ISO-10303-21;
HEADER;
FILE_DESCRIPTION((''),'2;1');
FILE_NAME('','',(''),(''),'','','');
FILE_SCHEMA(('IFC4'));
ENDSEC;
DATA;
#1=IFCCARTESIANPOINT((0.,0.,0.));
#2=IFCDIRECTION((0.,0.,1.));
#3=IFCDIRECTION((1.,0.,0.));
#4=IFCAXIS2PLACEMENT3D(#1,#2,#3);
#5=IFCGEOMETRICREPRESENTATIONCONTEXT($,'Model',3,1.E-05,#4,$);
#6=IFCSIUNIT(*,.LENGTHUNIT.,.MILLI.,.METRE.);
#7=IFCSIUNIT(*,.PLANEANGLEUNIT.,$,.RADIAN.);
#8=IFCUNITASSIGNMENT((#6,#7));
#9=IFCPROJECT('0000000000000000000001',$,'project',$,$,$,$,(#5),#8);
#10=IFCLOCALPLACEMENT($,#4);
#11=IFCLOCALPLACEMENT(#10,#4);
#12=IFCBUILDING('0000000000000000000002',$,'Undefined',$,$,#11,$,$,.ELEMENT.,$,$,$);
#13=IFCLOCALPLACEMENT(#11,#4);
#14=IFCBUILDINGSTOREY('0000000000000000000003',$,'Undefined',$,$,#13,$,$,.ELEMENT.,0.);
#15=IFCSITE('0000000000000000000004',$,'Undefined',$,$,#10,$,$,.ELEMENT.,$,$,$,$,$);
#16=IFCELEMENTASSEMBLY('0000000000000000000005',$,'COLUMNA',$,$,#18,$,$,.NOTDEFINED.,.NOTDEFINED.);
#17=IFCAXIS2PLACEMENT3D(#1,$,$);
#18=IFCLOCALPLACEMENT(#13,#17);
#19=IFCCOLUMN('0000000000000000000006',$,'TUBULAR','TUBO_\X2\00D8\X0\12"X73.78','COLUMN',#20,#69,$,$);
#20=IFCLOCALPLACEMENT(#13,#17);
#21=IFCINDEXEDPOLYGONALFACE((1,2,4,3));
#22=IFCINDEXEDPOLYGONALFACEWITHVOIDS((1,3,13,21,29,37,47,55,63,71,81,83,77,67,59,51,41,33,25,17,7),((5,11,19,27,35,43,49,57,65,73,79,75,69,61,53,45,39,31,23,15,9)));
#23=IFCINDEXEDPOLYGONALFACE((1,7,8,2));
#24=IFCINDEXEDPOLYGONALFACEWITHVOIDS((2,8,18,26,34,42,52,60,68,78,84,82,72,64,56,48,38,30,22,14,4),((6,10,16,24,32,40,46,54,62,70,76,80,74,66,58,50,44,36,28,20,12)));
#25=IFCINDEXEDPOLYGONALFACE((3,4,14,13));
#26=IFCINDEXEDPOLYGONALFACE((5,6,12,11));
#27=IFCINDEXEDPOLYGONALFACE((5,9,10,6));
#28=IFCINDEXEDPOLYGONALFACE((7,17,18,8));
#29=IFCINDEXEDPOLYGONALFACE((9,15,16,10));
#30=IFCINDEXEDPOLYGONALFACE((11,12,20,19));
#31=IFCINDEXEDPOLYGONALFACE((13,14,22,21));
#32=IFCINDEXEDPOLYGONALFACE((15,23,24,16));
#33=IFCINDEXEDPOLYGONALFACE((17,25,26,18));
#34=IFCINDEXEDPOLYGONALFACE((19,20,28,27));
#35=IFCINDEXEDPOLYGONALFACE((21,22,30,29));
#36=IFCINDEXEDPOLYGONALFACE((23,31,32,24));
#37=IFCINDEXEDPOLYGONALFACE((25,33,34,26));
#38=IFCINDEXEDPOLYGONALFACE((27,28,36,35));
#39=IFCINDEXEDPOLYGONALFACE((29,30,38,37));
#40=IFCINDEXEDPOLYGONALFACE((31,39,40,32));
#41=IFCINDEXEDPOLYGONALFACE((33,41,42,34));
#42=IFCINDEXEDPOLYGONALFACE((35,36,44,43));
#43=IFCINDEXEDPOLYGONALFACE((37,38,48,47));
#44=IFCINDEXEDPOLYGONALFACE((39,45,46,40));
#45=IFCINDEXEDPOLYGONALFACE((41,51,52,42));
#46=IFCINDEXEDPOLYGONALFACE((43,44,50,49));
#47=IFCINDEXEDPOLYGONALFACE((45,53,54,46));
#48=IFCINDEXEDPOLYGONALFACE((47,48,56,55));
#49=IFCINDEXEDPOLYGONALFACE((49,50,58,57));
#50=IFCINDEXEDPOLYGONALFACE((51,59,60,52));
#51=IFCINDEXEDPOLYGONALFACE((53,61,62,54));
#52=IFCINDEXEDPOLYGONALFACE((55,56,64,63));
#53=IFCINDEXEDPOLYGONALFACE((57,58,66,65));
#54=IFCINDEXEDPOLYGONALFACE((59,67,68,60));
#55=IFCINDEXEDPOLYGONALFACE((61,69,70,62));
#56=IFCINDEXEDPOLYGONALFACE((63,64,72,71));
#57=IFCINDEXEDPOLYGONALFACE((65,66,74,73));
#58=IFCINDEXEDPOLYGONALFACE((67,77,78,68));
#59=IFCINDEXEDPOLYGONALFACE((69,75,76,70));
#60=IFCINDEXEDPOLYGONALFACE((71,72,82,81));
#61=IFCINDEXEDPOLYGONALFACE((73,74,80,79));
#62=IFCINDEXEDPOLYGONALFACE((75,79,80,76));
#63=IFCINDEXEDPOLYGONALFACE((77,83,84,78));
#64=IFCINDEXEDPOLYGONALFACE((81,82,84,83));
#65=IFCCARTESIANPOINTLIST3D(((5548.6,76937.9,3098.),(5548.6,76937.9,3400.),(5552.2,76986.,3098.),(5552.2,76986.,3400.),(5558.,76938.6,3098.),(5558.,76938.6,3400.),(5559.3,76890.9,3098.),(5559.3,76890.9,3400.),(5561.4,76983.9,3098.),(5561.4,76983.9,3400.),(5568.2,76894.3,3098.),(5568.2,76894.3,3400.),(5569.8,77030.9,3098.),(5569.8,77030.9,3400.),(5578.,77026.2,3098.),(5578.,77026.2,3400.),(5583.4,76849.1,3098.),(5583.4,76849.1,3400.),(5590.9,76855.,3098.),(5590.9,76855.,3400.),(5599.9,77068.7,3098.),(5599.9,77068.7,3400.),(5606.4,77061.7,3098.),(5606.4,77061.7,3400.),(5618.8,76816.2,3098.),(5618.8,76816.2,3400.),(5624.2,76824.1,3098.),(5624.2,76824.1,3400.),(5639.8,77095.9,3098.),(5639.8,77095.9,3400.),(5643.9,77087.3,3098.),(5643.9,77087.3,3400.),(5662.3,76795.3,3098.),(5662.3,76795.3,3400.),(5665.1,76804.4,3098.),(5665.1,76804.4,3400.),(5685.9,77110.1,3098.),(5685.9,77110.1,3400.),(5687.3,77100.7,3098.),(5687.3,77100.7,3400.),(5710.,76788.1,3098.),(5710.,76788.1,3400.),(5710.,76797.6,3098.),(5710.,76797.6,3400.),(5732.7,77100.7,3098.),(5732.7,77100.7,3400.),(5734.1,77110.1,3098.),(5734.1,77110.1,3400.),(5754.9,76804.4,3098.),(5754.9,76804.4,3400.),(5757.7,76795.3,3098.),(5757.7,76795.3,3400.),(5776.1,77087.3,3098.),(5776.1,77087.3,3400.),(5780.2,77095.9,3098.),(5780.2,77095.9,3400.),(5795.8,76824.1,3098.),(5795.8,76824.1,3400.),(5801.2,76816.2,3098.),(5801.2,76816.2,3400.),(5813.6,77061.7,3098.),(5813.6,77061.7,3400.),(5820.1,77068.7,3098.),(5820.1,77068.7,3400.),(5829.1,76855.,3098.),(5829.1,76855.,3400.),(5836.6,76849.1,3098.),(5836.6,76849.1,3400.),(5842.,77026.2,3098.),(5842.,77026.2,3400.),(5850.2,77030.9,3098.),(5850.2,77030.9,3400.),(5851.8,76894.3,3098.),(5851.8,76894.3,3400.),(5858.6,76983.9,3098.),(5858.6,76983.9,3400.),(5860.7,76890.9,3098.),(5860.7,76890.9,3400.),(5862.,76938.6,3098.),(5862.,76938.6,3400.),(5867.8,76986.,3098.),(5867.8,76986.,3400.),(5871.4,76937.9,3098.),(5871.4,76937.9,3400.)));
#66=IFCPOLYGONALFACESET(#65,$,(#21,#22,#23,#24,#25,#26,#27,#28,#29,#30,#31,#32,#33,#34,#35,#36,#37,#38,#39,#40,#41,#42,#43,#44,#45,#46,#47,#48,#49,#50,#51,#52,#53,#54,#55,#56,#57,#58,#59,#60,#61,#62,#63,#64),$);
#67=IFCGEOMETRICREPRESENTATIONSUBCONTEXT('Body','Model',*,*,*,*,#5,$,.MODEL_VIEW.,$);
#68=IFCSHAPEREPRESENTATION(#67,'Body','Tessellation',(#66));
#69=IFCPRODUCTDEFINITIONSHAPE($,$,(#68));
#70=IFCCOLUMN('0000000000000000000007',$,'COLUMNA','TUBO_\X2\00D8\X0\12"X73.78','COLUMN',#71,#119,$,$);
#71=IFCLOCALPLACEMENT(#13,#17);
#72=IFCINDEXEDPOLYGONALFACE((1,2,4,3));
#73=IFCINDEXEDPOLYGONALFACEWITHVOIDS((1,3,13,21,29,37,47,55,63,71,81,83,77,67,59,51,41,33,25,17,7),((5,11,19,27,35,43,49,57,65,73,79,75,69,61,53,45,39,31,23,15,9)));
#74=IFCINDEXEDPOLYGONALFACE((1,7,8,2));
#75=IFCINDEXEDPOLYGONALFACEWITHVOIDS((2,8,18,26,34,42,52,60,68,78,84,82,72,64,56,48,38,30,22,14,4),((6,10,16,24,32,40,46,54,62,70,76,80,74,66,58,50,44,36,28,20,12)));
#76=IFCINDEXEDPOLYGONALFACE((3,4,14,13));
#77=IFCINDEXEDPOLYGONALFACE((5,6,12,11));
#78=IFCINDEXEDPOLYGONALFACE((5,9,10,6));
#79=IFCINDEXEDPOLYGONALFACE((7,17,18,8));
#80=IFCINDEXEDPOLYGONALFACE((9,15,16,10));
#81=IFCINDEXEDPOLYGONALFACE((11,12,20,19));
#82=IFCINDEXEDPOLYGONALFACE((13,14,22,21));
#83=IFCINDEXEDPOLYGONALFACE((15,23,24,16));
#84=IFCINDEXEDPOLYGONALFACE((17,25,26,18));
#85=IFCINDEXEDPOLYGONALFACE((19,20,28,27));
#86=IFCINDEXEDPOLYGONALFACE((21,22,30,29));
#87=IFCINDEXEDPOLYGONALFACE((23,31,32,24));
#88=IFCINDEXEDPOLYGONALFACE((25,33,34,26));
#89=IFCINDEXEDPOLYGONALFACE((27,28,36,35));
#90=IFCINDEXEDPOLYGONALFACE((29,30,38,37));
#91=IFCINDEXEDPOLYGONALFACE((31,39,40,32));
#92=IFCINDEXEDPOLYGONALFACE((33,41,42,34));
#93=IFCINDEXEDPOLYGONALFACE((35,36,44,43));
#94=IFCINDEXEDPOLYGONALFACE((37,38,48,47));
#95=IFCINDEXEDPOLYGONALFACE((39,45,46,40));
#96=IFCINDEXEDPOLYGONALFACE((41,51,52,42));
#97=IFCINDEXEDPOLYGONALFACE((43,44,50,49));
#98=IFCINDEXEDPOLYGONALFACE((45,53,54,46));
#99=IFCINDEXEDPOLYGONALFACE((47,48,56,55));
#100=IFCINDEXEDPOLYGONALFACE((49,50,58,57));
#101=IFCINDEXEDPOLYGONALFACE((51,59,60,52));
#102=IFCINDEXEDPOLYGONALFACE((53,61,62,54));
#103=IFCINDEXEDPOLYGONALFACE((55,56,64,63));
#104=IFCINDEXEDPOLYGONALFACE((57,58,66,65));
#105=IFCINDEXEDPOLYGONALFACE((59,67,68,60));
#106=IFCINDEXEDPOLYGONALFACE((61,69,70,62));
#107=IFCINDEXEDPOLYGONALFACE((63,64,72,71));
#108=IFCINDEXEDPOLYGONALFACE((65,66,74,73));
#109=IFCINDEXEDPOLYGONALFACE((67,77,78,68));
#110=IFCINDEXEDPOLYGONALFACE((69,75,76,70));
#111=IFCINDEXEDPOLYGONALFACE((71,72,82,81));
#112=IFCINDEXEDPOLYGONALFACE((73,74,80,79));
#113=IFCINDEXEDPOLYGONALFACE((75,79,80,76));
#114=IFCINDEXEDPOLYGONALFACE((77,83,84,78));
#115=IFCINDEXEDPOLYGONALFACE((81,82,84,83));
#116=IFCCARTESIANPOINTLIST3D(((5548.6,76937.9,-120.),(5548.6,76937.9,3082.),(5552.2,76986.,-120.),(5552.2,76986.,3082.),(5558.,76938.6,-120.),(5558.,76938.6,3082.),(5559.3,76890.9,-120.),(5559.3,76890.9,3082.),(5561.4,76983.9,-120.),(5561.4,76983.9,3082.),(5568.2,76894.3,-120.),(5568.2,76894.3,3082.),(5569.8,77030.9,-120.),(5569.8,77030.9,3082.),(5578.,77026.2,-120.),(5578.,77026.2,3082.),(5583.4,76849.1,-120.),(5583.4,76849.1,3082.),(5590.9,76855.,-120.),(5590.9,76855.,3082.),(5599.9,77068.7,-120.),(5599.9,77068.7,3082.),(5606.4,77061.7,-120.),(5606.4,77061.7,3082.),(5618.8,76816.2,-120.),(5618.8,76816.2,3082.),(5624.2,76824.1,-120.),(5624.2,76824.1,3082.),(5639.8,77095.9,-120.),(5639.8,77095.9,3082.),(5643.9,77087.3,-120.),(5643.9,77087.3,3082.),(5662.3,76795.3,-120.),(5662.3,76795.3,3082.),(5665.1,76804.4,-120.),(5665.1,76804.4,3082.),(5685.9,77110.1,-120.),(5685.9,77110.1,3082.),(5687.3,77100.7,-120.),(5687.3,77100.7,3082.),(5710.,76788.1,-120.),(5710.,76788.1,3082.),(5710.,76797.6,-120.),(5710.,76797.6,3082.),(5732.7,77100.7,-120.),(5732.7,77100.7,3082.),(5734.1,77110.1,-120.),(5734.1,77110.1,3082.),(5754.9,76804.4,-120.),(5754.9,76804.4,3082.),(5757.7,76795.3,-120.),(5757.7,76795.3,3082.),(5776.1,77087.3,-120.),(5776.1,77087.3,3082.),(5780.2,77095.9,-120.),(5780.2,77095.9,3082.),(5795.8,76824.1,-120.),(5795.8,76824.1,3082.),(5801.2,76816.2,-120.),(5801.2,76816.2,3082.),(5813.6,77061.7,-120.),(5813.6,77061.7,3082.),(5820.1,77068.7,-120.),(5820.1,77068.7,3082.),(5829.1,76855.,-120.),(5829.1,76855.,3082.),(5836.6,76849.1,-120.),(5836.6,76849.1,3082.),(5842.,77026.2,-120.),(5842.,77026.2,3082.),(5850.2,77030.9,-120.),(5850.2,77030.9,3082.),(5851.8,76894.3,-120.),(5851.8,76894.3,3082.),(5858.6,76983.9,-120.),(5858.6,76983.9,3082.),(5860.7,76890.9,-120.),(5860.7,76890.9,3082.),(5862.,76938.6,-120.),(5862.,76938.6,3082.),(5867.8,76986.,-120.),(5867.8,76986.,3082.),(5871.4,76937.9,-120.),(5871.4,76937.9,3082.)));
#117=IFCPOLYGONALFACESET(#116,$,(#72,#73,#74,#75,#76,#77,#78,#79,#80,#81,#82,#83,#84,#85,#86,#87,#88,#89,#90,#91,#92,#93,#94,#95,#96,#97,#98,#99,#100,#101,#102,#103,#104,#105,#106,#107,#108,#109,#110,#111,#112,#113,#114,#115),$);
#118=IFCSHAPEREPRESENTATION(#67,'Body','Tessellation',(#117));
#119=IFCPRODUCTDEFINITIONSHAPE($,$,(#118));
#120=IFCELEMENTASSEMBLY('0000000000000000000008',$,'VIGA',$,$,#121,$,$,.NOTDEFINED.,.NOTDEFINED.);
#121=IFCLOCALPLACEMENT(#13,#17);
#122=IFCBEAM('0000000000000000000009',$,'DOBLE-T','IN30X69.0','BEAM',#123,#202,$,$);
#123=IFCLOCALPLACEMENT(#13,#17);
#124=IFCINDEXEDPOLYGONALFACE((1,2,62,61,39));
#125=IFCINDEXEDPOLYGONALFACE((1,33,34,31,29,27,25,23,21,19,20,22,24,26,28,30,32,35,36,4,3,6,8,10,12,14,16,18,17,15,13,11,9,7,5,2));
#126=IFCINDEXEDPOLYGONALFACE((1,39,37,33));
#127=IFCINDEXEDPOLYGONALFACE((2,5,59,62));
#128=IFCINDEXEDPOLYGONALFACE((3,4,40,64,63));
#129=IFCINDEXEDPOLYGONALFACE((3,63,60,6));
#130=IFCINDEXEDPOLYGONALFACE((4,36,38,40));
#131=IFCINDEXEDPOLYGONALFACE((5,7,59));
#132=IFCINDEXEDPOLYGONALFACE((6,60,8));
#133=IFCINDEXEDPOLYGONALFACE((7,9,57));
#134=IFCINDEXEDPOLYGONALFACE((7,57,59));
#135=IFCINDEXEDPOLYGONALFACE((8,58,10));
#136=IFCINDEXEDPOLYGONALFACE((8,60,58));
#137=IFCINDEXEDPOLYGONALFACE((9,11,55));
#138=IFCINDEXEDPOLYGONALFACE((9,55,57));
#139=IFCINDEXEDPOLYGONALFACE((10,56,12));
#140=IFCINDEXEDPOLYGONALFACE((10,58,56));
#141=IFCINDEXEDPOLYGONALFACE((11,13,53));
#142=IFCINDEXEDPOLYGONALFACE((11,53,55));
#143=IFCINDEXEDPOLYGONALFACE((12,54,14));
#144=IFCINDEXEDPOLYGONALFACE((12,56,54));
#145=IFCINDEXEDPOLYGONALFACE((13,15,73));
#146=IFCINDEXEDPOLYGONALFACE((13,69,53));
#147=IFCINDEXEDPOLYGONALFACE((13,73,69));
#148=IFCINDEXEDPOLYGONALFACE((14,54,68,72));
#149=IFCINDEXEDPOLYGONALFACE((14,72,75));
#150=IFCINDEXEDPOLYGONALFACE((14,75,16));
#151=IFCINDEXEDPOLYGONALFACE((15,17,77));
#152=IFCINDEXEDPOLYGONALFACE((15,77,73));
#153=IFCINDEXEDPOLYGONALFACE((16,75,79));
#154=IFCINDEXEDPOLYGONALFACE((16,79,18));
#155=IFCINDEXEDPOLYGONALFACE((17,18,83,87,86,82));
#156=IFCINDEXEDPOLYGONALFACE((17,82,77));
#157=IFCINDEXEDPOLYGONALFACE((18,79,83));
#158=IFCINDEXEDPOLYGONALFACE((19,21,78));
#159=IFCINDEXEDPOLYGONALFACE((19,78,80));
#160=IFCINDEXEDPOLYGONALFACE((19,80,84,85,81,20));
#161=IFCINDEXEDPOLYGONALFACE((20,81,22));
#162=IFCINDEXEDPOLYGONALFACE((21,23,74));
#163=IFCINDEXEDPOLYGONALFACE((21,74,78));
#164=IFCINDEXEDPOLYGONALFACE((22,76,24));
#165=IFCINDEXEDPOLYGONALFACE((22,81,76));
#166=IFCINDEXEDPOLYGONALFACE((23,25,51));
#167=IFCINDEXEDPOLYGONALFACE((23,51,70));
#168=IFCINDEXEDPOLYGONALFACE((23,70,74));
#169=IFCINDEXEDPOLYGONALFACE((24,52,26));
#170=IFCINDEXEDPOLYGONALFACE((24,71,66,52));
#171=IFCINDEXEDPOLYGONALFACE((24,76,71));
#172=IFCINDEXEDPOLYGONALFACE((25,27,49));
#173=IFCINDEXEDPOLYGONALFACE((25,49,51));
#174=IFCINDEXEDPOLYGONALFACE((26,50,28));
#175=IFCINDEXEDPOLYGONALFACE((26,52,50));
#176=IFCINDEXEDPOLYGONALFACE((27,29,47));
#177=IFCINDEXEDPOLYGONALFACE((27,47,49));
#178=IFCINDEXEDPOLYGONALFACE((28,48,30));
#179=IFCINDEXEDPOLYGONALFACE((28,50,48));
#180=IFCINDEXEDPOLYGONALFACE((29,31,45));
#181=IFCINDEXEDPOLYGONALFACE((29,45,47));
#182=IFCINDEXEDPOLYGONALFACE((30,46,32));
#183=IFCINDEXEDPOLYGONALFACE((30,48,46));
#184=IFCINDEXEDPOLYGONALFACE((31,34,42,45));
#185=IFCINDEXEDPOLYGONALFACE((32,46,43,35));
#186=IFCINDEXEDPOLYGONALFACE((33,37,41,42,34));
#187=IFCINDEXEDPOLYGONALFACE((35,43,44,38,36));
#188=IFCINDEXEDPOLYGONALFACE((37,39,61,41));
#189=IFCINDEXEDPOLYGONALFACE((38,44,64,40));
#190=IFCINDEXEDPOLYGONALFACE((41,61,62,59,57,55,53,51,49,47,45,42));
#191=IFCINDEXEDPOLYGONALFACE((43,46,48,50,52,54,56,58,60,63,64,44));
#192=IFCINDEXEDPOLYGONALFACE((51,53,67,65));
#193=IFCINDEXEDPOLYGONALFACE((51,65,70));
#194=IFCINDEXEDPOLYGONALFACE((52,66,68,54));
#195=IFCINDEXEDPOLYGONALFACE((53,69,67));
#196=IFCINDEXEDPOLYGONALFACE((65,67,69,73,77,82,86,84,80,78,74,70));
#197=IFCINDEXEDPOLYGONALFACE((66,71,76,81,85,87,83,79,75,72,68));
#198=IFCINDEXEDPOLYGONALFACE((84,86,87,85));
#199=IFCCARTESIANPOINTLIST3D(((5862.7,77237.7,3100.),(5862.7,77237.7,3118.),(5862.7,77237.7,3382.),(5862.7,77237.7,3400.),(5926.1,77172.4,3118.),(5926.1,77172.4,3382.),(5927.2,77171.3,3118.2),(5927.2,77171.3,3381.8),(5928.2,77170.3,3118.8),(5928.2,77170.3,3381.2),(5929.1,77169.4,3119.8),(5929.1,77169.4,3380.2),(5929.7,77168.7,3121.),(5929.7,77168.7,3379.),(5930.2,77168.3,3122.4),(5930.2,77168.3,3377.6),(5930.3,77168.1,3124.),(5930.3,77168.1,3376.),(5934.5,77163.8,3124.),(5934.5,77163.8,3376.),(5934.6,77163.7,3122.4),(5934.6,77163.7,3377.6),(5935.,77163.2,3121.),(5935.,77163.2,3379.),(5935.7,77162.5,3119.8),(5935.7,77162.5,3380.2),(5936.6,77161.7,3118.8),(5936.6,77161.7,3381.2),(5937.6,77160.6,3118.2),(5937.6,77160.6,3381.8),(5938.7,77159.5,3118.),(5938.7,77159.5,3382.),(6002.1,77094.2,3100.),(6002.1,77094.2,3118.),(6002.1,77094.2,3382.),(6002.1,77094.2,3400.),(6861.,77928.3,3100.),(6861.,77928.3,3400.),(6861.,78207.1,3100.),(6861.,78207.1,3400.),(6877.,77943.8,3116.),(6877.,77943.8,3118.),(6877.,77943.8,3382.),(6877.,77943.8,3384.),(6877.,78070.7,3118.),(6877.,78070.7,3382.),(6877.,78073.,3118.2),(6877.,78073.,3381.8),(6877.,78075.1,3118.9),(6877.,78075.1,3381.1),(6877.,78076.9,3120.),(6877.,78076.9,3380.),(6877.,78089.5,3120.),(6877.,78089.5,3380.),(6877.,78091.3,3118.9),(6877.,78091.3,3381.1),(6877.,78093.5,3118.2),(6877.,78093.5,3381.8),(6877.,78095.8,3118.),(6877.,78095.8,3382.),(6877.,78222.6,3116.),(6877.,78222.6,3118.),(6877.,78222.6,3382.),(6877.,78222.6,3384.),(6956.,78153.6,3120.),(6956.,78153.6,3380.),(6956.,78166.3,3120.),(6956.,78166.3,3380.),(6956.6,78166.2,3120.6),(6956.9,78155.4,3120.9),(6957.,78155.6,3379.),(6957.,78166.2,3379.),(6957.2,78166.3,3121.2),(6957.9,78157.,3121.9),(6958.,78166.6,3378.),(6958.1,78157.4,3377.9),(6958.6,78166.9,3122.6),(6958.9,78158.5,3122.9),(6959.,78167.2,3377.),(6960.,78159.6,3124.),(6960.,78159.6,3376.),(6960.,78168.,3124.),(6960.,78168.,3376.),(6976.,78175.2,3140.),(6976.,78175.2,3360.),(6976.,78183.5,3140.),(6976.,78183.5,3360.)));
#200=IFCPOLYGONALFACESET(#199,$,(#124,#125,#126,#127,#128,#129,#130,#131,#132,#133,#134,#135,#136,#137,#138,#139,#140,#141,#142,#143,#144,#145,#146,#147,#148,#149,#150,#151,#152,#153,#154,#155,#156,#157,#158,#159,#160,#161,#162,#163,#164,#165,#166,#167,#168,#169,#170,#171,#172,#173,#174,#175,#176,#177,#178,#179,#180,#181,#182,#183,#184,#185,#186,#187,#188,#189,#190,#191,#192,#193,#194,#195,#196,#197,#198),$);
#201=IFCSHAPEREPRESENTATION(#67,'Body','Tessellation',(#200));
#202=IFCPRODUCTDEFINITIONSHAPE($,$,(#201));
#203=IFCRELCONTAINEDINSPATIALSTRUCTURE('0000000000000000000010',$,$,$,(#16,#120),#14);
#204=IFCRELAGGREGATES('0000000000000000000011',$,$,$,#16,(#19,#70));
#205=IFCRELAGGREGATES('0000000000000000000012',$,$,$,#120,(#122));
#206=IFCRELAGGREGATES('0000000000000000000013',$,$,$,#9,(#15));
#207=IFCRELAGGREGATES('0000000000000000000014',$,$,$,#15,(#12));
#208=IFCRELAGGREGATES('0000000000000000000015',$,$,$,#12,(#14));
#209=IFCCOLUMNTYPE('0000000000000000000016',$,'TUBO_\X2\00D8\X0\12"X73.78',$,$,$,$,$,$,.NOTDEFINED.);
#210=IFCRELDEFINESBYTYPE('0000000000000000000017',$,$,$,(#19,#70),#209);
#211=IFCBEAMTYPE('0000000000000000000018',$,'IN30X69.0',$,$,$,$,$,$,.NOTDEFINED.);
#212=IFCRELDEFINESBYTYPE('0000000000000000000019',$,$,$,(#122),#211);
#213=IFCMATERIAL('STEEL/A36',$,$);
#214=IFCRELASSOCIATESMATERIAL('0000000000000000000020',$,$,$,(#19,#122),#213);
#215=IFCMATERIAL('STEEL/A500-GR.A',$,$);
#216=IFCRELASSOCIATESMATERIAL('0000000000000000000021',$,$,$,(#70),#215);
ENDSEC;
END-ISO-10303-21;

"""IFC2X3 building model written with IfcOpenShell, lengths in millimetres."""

from ifc_helpers import new_model, si_unit, frame, origin_with_axes, origin_2d_with_axis, place, context, subcontext, project, spatial, polyline, hollow_circle, i_section, outline, extrude, boolean, halfspace, material, type_object, element, aggregate, save


model = new_model("IFC2X3")

# Units and contexts
model_context = context("Model", 3, precision=1e-05, world=origin_with_axes())
body_context = subcontext(model_context, "Body", "Model", "MODEL_VIEW")
ifc_project = project(units=[si_unit("LENGTHUNIT", "METRE", prefix="MILLI"), si_unit("PLANEANGLEUNIT", "RADIAN")], contexts=[model_context])

# Site, building, storey
site_placement = place(None, origin_with_axes())
site = spatial("IfcSite", under=ifc_project, at=site_placement, Name="Undefined", CompositionType="ELEMENT")
building_placement = place(site_placement, origin_with_axes())
building = spatial("IfcBuilding", under=site, at=building_placement, Name="Undefined", CompositionType="ELEMENT")
storey_placement = place(building_placement, origin_with_axes())
storey = spatial("IfcBuildingStorey", under=building, at=storey_placement, Name="Undefined", CompositionType="ELEMENT", Elevation=0.0)

# Element assembly, columns
assembly_1_placement = place(storey_placement, origin_with_axes())
assembly_1 = element("IfcElementAssembly", 1, at=assembly_1_placement, inside=storey, Name="COLUMNA", AssemblyPlace="NOTDEFINED", PredefinedType="NOTDEFINED")
ifc_material_1 = material(Name="STEEL/A36")
column_type = type_object("IfcColumnType", Name="TUBO_Ø12\"X73.78", PredefinedType="NOTDEFINED")
column_1_placement = place(assembly_1_placement, frame((5710.0, 76950.0, 3098.0), z_axis=(0.0, 0.0, 1.0), x_axis=(-1.0, 0.0, 0.0)))
column_1 = element("IfcColumn", 2, at=column_1_placement, type_object=column_type, material=ifc_material_1, Name="TUBULAR", Description="TUBO_Ø12\"X73.78", ObjectType="COLUMN", context=body_context, shape_type="SweptSolid", body=[
    extrude(hollow_circle(Radius=161.9, WallThickness=9.5, at=origin_2d_with_axis()), frame((0.0, 0.0, 302.0), z_axis=(0.0, 0.0, -1.0), x_axis=(0.0, 1.0, 0.0)), (0.0, 0.0, 1.0), 302.0),
])
ifc_material_2 = material(Name="STEEL/A500-GR.A")
column_2_placement = place(assembly_1_placement, frame((5710.0, 76950.0, -120.0), z_axis=(0.0, 0.0, 1.0), x_axis=(-1.0, 0.0, 0.0)))
column_2 = element("IfcColumn", 3, at=column_2_placement, type_object=column_type, material=ifc_material_2, Name="COLUMNA", Description="TUBO_Ø12\"X73.78", ObjectType="COLUMN", context=body_context, shape_type="SweptSolid", body=[
    extrude(hollow_circle(Radius=161.9, WallThickness=9.5, at=origin_2d_with_axis()), frame((0.0, 0.0, 3202.0), z_axis=(0.0, 0.0, -1.0), x_axis=(0.0, 1.0, 0.0)), (0.0, 0.0, 1.0), 3202.0),
])

# Element assembly, beam
assembly_2_placement = place(storey_placement, origin_with_axes())
assembly_2 = element("IfcElementAssembly", 4, at=assembly_2_placement, inside=storey, Name="VIGA", AssemblyPlace="NOTDEFINED", PredefinedType="NOTDEFINED")
beam_type = type_object("IfcBeamType", Name="IN30X69.0", PredefinedType="NOTDEFINED")
beam_placement = place(assembly_2_placement, frame((6979.0, 78182.3, 3250.0), z_axis=(0.0, 0.0, 1.0), x_axis=(-0.71741, -0.696651, 0.0)))
beam = element("IfcBeam", 5, at=beam_placement, type_object=beam_type, material=ifc_material_1, Name="DOBLE-T", Description="IN30X69.0", ObjectType="BEAM", context=body_context, shape_type="CSG", body=[
    boolean("DIFFERENCE", boolean("DIFFERENCE", boolean("DIFFERENCE", boolean("DIFFERENCE", boolean("DIFFERENCE", boolean("DIFFERENCE", boolean("DIFFERENCE", extrude(i_section(OverallWidth=200.0, OverallDepth=300.0, WebThickness=6.0, FlangeThickness=18.0, FilletRadius=6.0, at=origin_2d_with_axis()), frame((1768.9, 0.0, 0.0), z_axis=(-1.0, 0.0, 0.0), x_axis=(0.0, -1.0, 0.0)), (0.0, 0.0, 1.0), 1896.0), extrude(outline(polyline([(0.0, 0.0), (20.0, 0.0), (20.0, 20.0), (0.0, 0.0)])), frame((786.4, 805.6, -110.0), z_axis=(-0.696651, -0.71741, 0.0), x_axis=(0.0, 0.0, -1.0)), (0.0, 0.0, 1.0), 1169.0)), extrude(outline(polyline([(0.0, 0.0), (20.0, 0.0), (20.0, 20.0), (0.0, 0.0)])), frame((800.8, 791.6, 130.0), z_axis=(-0.696651, -0.71741, 0.0), x_axis=(-0.71741, 0.696651, 0.0)), (0.0, 0.0, 1.0), 1169.0)), extrude(outline(polyline([(0.0, 0.0), (16.0, 0.0), (16.0, 16.0), (0.0, 0.0)])), frame((-12.9, -182.6, -150.0), z_axis=(0.696651, 0.71741, 0.0), x_axis=(-0.71741, 0.696651, 0.0)), (0.0, 0.0, 1.0), 500.0)), extrude(outline(polyline([(0.0, 0.0), (16.0, 0.0), (16.0, 16.0), (0.0, 0.0)])), frame((335.4, 176.1, 150.0), z_axis=(-0.696651, -0.71741, 0.0), x_axis=(-0.71741, 0.696651, 0.0)), (0.0, 0.0, 1.0), 500.0)), extrude(outline(polyline([(0.0, 0.0), (304.0, 0.0), (304.0, 104.0), (282.0, 104.0), (282.0, 5.0), (22.0, 5.0), (22.0, 104.0), (0.0, 104.0), (0.0, 0.0)])), frame((-133.8, -134.9, -152.0), z_axis=(0.696651, 0.71741, 0.0), x_axis=(0.0, 0.0, 1.0)), (0.0, 0.0, 1.0), 500.0)), halfspace(frame((1458.9, -100.0, 150.0), z_axis=(1.0, 0.0, 0.0), x_axis=(0.0, 0.0, 1.0)), False)), halfspace(frame((234.2, 241.2, 150.0), z_axis=(-0.71741, 0.696651, 0.0), x_axis=(0.0, 0.0, 1.0)), False)),
])

aggregate(assembly_1, [column_1, column_2])
aggregate(assembly_2, [beam])

save(model, "model.ifc")
